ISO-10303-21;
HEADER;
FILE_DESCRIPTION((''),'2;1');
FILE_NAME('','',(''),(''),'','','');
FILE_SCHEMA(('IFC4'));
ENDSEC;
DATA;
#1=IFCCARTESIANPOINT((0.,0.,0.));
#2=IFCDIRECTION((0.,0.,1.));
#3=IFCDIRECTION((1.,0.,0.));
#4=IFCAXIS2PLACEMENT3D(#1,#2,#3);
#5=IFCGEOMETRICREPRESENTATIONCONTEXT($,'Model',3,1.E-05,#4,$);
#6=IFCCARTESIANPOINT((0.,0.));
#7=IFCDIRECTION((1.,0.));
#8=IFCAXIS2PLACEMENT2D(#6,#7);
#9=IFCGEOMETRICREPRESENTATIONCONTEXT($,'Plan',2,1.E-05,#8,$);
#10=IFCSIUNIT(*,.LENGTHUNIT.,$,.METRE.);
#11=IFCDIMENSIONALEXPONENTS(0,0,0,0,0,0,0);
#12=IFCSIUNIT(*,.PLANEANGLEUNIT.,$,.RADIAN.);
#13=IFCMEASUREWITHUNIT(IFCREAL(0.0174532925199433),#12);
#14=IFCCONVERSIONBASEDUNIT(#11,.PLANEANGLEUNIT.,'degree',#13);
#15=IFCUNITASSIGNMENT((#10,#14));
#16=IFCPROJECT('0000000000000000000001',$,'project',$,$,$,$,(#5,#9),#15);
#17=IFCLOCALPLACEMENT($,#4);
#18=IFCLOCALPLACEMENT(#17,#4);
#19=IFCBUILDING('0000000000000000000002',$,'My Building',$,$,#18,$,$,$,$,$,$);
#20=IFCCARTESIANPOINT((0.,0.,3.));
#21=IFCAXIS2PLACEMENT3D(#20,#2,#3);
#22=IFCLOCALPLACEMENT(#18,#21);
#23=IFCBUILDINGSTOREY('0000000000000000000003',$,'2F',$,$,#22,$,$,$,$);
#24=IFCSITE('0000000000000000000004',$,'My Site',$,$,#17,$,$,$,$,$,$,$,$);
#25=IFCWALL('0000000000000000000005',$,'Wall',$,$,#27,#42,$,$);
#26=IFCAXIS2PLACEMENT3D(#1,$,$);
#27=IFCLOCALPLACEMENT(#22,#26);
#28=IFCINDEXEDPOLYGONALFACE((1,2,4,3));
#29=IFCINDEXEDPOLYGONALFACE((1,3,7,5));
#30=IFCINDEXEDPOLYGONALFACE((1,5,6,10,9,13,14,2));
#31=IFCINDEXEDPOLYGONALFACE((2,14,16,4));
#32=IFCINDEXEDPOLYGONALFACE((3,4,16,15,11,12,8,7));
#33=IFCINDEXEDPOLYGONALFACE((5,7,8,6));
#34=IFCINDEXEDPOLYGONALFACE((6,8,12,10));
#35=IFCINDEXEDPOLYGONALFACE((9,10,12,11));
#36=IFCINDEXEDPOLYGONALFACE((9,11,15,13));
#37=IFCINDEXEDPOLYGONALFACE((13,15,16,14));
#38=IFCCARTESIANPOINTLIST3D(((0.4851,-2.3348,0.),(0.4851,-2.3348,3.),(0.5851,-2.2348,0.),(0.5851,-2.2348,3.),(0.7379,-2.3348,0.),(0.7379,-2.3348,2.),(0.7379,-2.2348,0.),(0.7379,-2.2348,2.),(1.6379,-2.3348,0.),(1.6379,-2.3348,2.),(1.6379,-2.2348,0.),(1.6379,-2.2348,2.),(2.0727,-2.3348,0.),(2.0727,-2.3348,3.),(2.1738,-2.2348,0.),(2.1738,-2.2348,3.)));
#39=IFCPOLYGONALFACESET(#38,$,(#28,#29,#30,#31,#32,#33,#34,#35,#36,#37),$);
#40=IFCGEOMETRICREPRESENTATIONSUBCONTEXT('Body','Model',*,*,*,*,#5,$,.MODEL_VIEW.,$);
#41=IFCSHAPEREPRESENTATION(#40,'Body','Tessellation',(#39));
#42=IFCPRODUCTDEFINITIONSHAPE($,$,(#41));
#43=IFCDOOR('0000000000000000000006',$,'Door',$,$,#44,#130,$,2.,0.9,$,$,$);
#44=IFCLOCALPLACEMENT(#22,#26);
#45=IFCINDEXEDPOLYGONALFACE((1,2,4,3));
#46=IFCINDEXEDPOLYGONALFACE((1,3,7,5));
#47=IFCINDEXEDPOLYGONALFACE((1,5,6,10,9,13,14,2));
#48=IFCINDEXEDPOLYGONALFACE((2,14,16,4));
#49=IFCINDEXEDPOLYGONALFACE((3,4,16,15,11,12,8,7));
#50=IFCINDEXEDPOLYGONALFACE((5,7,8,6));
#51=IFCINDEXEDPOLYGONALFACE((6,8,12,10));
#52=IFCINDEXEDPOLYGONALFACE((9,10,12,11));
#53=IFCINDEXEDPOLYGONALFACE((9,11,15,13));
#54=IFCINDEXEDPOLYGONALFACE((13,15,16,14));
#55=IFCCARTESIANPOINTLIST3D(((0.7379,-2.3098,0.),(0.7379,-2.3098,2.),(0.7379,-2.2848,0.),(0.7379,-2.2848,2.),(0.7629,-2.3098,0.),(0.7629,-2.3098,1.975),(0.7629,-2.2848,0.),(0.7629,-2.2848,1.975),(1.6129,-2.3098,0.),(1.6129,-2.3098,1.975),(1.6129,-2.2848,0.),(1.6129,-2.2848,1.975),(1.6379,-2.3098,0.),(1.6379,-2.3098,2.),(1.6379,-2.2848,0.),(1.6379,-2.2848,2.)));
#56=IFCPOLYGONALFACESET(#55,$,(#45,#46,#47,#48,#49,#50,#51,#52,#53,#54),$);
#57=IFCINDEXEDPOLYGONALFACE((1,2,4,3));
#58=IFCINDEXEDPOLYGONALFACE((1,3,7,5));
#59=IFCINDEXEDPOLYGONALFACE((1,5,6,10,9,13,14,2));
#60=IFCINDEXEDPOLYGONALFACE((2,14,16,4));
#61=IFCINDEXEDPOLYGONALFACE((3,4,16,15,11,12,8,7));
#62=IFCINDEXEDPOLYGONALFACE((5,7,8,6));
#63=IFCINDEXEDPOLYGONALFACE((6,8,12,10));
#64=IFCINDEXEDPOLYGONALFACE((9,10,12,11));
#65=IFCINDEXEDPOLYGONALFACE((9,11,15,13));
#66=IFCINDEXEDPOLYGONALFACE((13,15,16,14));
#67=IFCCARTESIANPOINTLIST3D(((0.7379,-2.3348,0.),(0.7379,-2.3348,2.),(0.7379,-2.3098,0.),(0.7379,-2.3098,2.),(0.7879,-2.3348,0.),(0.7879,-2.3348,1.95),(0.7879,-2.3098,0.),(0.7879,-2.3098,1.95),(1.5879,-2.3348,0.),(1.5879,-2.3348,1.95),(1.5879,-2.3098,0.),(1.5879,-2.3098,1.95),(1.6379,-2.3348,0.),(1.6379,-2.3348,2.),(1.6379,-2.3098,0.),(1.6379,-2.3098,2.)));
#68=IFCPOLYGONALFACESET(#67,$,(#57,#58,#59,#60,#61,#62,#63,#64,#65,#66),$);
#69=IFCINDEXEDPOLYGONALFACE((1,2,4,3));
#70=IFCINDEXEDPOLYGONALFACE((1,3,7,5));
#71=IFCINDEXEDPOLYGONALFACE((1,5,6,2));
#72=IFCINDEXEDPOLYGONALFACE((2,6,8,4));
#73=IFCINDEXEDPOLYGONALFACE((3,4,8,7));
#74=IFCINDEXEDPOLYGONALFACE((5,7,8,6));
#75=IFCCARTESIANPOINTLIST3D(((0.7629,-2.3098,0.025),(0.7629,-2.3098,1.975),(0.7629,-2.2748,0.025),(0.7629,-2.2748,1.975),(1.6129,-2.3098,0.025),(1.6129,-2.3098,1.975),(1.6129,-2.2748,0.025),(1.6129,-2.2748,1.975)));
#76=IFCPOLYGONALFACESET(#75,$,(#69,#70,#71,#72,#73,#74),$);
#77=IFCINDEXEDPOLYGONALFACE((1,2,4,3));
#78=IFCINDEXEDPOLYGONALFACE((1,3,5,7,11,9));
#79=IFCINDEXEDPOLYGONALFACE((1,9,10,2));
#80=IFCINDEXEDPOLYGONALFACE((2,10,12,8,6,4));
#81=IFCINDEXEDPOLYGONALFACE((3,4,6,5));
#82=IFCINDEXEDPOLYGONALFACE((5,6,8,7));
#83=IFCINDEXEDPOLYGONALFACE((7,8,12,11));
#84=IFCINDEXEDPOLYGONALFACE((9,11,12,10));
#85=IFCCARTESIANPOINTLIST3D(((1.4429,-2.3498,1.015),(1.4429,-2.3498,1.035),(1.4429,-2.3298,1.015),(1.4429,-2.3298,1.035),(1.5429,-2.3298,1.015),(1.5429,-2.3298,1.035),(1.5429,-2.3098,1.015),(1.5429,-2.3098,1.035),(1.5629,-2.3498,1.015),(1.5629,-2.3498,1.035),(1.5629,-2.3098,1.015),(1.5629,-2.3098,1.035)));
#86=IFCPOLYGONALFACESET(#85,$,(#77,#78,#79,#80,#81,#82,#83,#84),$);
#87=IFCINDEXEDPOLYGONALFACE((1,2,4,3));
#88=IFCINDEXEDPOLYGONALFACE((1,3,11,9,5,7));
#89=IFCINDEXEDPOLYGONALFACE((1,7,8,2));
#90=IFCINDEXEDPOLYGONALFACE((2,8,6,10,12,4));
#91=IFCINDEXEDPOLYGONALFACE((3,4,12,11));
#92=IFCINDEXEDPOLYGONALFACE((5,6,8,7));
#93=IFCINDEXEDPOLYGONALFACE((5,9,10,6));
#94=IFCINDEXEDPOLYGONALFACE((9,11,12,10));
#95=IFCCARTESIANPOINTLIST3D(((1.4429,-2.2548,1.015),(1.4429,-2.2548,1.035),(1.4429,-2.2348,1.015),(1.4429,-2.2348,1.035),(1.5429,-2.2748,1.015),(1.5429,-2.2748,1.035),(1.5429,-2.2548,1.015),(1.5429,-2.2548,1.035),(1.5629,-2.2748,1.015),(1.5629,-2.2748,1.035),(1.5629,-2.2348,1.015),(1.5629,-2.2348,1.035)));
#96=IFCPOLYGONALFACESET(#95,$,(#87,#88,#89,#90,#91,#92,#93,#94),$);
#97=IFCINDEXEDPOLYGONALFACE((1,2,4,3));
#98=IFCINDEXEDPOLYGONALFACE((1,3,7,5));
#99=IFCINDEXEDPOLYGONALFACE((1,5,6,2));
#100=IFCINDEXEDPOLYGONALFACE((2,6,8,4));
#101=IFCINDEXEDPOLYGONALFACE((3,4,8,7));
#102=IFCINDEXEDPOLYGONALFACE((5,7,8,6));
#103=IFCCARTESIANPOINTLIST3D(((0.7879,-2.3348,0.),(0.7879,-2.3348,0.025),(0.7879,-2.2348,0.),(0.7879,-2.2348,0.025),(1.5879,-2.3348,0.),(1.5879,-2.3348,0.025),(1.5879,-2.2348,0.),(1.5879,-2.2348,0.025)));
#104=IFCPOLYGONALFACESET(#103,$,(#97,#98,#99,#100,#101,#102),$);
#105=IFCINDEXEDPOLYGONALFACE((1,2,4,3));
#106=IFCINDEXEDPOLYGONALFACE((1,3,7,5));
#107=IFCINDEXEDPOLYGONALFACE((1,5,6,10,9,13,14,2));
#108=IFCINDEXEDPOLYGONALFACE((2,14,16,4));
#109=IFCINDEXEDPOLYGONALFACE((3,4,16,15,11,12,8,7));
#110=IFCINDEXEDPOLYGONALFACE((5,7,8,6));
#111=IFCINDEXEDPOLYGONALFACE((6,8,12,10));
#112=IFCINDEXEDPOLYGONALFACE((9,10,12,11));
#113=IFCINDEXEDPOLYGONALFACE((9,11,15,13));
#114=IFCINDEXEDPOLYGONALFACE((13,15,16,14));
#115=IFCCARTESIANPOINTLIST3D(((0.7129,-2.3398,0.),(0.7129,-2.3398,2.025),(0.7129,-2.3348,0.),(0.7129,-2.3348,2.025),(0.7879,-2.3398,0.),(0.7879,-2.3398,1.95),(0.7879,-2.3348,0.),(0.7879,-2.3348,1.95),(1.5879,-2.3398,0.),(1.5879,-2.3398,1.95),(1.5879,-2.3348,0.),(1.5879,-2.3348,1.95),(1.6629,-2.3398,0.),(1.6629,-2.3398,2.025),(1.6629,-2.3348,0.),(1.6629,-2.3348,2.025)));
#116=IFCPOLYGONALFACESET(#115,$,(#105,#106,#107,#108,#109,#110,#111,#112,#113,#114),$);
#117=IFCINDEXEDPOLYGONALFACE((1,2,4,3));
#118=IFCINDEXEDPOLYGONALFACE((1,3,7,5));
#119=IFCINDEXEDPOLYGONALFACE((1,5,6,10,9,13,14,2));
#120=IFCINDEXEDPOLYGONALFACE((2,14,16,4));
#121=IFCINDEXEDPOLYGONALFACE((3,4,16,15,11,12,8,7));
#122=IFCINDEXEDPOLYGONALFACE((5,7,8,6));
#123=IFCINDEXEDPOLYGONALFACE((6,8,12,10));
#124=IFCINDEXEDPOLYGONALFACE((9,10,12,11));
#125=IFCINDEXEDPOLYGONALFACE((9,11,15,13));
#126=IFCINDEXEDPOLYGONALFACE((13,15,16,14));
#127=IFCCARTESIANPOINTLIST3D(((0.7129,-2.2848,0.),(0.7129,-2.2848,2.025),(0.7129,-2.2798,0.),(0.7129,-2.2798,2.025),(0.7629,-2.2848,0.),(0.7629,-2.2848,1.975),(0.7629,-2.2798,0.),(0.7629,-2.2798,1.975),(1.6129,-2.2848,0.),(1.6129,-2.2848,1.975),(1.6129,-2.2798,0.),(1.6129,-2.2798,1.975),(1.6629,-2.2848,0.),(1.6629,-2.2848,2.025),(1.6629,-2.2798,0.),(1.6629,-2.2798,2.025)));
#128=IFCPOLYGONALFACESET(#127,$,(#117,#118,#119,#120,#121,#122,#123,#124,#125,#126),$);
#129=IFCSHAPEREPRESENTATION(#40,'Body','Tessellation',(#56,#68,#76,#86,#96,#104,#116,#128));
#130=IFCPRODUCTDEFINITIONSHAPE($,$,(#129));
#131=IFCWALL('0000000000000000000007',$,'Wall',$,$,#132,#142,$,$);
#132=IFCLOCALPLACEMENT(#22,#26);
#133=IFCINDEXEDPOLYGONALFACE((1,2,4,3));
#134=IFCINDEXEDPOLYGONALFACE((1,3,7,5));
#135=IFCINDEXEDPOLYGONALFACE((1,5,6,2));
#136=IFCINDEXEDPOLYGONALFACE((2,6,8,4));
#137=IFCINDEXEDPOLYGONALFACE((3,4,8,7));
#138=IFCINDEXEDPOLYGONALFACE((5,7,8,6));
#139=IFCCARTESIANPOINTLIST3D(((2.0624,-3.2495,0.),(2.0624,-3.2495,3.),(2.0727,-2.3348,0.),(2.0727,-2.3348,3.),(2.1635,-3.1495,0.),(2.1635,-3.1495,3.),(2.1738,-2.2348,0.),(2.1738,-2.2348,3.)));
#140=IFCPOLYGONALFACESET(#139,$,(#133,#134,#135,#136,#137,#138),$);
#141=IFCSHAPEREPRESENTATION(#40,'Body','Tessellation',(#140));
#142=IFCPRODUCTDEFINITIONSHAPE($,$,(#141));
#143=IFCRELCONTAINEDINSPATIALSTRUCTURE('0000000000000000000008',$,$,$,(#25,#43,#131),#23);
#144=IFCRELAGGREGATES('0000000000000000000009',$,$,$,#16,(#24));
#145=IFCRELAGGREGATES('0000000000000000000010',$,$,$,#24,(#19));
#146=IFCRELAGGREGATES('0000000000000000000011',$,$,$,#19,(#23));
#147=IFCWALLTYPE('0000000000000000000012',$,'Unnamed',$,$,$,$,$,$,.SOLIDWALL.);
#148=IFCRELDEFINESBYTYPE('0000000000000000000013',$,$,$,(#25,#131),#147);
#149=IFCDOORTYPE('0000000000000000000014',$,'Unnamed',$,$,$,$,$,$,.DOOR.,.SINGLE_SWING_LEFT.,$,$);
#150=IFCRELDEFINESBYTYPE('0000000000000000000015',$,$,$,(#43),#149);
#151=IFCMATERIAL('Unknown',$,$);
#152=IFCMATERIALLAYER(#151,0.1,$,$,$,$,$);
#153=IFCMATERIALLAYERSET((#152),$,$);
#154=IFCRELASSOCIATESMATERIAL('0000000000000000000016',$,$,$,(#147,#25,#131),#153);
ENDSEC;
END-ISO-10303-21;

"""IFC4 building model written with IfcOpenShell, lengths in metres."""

from ifc_helpers import new_model, entity, si_unit, converted_unit, frame, origin_with_axes, origin_2d_with_axis, place, context, subcontext, project, spatial, line, indexed_curve, outline, extrude, shape, source, transform, mapped, material, layer, layer_set, layer_usage, type_object, type_shapes, element, fill, save


model = new_model("IFC4")

# Units and contexts
model_context = context("Model", 3, precision=1e-05, world=origin_with_axes())
plan_context = context("Plan", 2, precision=1e-05, world=origin_2d_with_axis())
body_context_1 = subcontext(model_context, "Body", "Model", "MODEL_VIEW")
body_context_2 = subcontext(plan_context, "Body", "Plan", "PLAN_VIEW")
ifc_project = project(units=[si_unit("LENGTHUNIT", "METRE"), converted_unit("PLANEANGLEUNIT", "degree", entity("IfcReal", 0.0174532925199433), si_unit("PLANEANGLEUNIT", "RADIAN"), dimensions=[0, 0, 0, 0, 0, 0, 0])], contexts=[model_context, plan_context])

# Site, building, storey
site_placement = place(None, origin_with_axes())
site = spatial("IfcSite", under=ifc_project, at=site_placement, Name="My Site")
building_placement = place(site_placement, origin_with_axes())
building = spatial("IfcBuilding", under=site, at=building_placement, Name="My Building")
storey_placement = place(building_placement, frame((0.0, 0.0, 3.0), z_axis=(0.0, 0.0, 1.0), x_axis=(1.0, 0.0, 0.0)))
storey = spatial("IfcBuildingStorey", under=building, at=storey_placement, Name="2F")

# Shared definitions
ifc_material = material(Name="Unknown")

# Shared definitions
ifc_layer_1 = layer(ifc_material, 0.1)
ifc_layer_set_1 = layer_set([ifc_layer_1])
wall_type = type_object("IfcWallType", Name="Unnamed", PredefinedType="SOLIDWALL", material=ifc_layer_set_1)

# Shared definitions
shared_shape_1 = source(origin_with_axes(), body_context_1, "Body", "SweptSolid", [
    extrude(outline(indexed_curve([(0.0, 0.0), (0.9, 0.0), (0.9, 2.0), (0.0, 2.0)], segments=[line(1, 2, 3, 4, 1)])), frame((0.0, -0.6, 0.0), z_axis=(0.0, -1.0, 0.0), x_axis=(1.0, 0.0, 0.0)), (0.0, 0.0, -1.0), 1.2),
])
door_type_1 = type_object("IfcDoorType", Name="Unnamed", OperationType="SINGLE_SWING_LEFT", PredefinedType="DOOR")
shared_shape_2 = source(origin_with_axes(), body_context_1, "Body", "SweptSolid", [
    extrude(outline(indexed_curve([(0.0, 0.0), (0.0, 2.0), (0.9, 2.0), (0.9, 0.0), (0.875, 0.0), (0.875, 1.975), (0.025, 1.975), (0.025, 0.0)], segments=[line(1, 2, 3, 4, 5, 6, 7, 8, 1)])), frame((0.0, 0.025, 0.0), z_axis=(0.0, -1.0, 0.0), x_axis=(1.0, 0.0, 0.0)), (0.0, 0.0, -1.0), 0.025),
    extrude(outline(indexed_curve([(0.0, 0.0), (0.0, 2.0), (0.9, 2.0), (0.9, 0.0), (0.85, 0.0), (0.85, 1.95), (0.05, 1.95), (0.05, 0.0)], segments=[line(1, 2, 3, 4, 5, 6, 7, 8, 1)])), frame((0.0, 0.0, 0.0), z_axis=(0.0, -1.0, 0.0), x_axis=(1.0, 0.0, 0.0)), (0.0, 0.0, -1.0), 0.025),
    extrude(outline(indexed_curve([(0.0, 0.0), (0.85, 0.0), (0.85, 0.035), (0.0, 0.035)], segments=[line(1, 2, 3, 4, 1)])), frame((0.025, 0.025, 0.025), z_axis=(0.0, 0.0, 1.0), x_axis=(1.0, 0.0, 0.0)), (0.0, 0.0, 1.0), 1.95),
    extrude(outline(indexed_curve([(0.0, 0.0), (0.0, -0.04), (-0.12, -0.04), (-0.12, -0.02), (-0.02, -0.02), (-0.02, 0.0)], segments=[line(1, 2, 3, 4, 5, 6, 1)])), frame((0.825, 0.025, 1.015), z_axis=(0.0, 0.0, 1.0), x_axis=(1.0, 0.0, 0.0)), (0.0, 0.0, 1.0), 0.02),
    extrude(outline(indexed_curve([(0.0, 0.0), (0.0, 0.04), (-0.12, 0.04), (-0.12, 0.02), (-0.02, 0.02), (-0.02, 0.0)], segments=[line(1, 2, 3, 4, 5, 6, 1)])), frame((0.825, 0.06, 1.015), z_axis=(0.0, 0.0, 1.0), x_axis=(1.0, 0.0, 0.0)), (0.0, 0.0, 1.0), 0.02),
    extrude(outline(indexed_curve([(0.0, 0.0), (0.8, 0.0), (0.8, 0.1), (0.0, 0.1)], segments=[line(1, 2, 3, 4, 1)])), frame((0.05, 0.0, 0.0), z_axis=(0.0, 0.0, 1.0), x_axis=(1.0, 0.0, 0.0)), (0.0, 0.0, 1.0), 0.025),
    extrude(outline(indexed_curve([(0.0, 0.0), (0.0, 2.025), (0.95, 2.025), (0.95, 0.0), (0.875, 0.0), (0.875, 1.95), (0.075, 1.95), (0.075, 0.0)], segments=[line(1, 2, 3, 4, 5, 6, 7, 8, 1)])), frame((-0.025, -0.005, 0.0), z_axis=(0.0, -1.0, 0.0), x_axis=(1.0, 0.0, 0.0)), (0.0, 0.0, -1.0), 0.005),
    extrude(outline(indexed_curve([(0.0, 0.0), (0.0, 2.025), (0.95, 2.025), (0.95, 0.0), (0.9, 0.0), (0.9, 1.975), (0.05, 1.975), (0.05, 0.0)], segments=[line(1, 2, 3, 4, 5, 6, 7, 8, 1)])), frame((-0.025, 0.05, 0.0), z_axis=(0.0, -1.0, 0.0), x_axis=(1.0, 0.0, 0.0)), (0.0, 0.0, -1.0), 0.005),
])
shared_shape_3 = source(origin_with_axes(), body_context_2, "Body", "Curve2D", [
    entity("IfcIndexedPolyCurve", entity("IfcCartesianPointList2D", [[0.0, 0.0], [0.0, 0.05], [0.025, 0.05], [0.025, 0.025], [0.05, 0.025], [0.05, 0.0]]), [entity("IfcLineIndex", [1, 2, 3, 4, 5, 6, 1])]),
    entity("IfcIndexedPolyCurve", entity("IfcCartesianPointList2D", [[0.9, 0.0], [0.9, 0.05], [0.875, 0.05], [0.875, 0.025], [0.85, 0.025], [0.85, 0.0]]), [entity("IfcLineIndex", [1, 2, 3, 4, 5, 6, 1])]),
    entity("IfcTrimmedCurve", entity("IfcEllipse", entity("IfcAxis2Placement2D", entity("IfcCartesianPoint", [0.06, 0.05]), entity("IfcDirection", [1.0, 0.0])), 0.815, 0.85), [entity("IfcCartesianPoint", [0.875, 0.05])], [entity("IfcCartesianPoint", [0.06, 0.9])], True, "CARTESIAN"),
    entity("IfcIndexedPolyCurve", entity("IfcCartesianPointList2D", [[0.025, 0.05], [0.06, 0.05], [0.06, 0.9], [0.025, 0.9]]), [entity("IfcLineIndex", [1, 2, 3, 4, 1])]),
])
type_shapes(door_type_1, [shared_shape_2, shared_shape_3])

# Wall, opening, door
ifc_layer_usage_1 = layer_usage(ifc_layer_set_1, "AXIS2", "POSITIVE", 0.0)
wall_1_placement = place(storey_placement, frame((0.4851, -2.3348, 0.0), z_axis=(0.0, 0.0, 1.0), x_axis=(1.0, 0.000001, 0.0)))
wall_1 = element("IfcWall", 1, at=wall_1_placement, inside=storey, type_object=wall_type, material=ifc_layer_usage_1, Name="Wall", context=body_context_1, shape_type="SweptSolid", body=[
    extrude(outline(indexed_curve([(0.0, 0.0), (0.1, 0.1), (1.6887, 0.1), (1.5876, 0.0)], segments=[line(1, 2, 3, 4, 1)])), origin_with_axes(), (0.0, 0.0, 1.0), 3.0),
])
opening_1_placement = place(wall_1_placement, frame((0.2528, 0.0, 0.0), z_axis=(0.0, 0.0, 1.0), x_axis=(1.0, 0.0, 0.0)))
opening_1 = element("IfcOpeningElement", 2, at=opening_1_placement, cuts=wall_1, PredefinedType="OPENING", context=body_context_1, shape_type="MappedRepresentation", body=[
    mapped(shared_shape_1, transform((0.0, 0.0, 0.0), x_axis=(1.0, 0.0, 0.0), y_axis=(0.0, 1.0, 0.0), z_axis=(0.0, 0.0, 1.0), scale=1.0)),
])
door_1_placement = place(opening_1_placement, origin_with_axes())
door_1 = element("IfcDoor", 3, at=door_1_placement, inside=storey, type_object=door_type_1, Name="Door", OverallHeight=2.0, OverallWidth=0.9, shapes=[
    shape(body_context_1, "Body", "MappedRepresentation", [mapped(shared_shape_2, transform((0.0, 0.0, 0.0), x_axis=(1.0, 0.0, 0.0), y_axis=(0.0, 1.0, 0.0), z_axis=(0.0, 0.0, 1.0), scale=1.0))]),
    shape(body_context_2, "Body", "MappedRepresentation", [mapped(shared_shape_3, transform((0.0, 0.0, 0.0), x_axis=(1.0, 0.0, 0.0), y_axis=(0.0, 1.0, 0.0), z_axis=(0.0, 0.0, 1.0), scale=1.0))]),
])
fill(opening_1, door_1)

# Wall
ifc_layer_usage_2 = layer_usage(ifc_layer_set_1, "AXIS2", "POSITIVE", 0.0)
wall_2_placement = place(storey_placement, frame((2.0727, -2.3348, 0.0), z_axis=(0.0, 0.0, 1.0), x_axis=(-0.011274, -0.999936, 0.0)))
element("IfcWall", 4, at=wall_2_placement, inside=storey, type_object=wall_type, material=ifc_layer_usage_2, Name="Wall", context=body_context_1, shape_type="SweptSolid", body=[
    extrude(outline(indexed_curve([(0.0, 0.0), (-0.1011, 0.1), (0.8137, 0.1), (0.9148, 0.0)], segments=[line(1, 2, 3, 4, 1)])), origin_with_axes(), (0.0, 0.0, 1.0), 3.0),
])

save(model, "model.ifc")
